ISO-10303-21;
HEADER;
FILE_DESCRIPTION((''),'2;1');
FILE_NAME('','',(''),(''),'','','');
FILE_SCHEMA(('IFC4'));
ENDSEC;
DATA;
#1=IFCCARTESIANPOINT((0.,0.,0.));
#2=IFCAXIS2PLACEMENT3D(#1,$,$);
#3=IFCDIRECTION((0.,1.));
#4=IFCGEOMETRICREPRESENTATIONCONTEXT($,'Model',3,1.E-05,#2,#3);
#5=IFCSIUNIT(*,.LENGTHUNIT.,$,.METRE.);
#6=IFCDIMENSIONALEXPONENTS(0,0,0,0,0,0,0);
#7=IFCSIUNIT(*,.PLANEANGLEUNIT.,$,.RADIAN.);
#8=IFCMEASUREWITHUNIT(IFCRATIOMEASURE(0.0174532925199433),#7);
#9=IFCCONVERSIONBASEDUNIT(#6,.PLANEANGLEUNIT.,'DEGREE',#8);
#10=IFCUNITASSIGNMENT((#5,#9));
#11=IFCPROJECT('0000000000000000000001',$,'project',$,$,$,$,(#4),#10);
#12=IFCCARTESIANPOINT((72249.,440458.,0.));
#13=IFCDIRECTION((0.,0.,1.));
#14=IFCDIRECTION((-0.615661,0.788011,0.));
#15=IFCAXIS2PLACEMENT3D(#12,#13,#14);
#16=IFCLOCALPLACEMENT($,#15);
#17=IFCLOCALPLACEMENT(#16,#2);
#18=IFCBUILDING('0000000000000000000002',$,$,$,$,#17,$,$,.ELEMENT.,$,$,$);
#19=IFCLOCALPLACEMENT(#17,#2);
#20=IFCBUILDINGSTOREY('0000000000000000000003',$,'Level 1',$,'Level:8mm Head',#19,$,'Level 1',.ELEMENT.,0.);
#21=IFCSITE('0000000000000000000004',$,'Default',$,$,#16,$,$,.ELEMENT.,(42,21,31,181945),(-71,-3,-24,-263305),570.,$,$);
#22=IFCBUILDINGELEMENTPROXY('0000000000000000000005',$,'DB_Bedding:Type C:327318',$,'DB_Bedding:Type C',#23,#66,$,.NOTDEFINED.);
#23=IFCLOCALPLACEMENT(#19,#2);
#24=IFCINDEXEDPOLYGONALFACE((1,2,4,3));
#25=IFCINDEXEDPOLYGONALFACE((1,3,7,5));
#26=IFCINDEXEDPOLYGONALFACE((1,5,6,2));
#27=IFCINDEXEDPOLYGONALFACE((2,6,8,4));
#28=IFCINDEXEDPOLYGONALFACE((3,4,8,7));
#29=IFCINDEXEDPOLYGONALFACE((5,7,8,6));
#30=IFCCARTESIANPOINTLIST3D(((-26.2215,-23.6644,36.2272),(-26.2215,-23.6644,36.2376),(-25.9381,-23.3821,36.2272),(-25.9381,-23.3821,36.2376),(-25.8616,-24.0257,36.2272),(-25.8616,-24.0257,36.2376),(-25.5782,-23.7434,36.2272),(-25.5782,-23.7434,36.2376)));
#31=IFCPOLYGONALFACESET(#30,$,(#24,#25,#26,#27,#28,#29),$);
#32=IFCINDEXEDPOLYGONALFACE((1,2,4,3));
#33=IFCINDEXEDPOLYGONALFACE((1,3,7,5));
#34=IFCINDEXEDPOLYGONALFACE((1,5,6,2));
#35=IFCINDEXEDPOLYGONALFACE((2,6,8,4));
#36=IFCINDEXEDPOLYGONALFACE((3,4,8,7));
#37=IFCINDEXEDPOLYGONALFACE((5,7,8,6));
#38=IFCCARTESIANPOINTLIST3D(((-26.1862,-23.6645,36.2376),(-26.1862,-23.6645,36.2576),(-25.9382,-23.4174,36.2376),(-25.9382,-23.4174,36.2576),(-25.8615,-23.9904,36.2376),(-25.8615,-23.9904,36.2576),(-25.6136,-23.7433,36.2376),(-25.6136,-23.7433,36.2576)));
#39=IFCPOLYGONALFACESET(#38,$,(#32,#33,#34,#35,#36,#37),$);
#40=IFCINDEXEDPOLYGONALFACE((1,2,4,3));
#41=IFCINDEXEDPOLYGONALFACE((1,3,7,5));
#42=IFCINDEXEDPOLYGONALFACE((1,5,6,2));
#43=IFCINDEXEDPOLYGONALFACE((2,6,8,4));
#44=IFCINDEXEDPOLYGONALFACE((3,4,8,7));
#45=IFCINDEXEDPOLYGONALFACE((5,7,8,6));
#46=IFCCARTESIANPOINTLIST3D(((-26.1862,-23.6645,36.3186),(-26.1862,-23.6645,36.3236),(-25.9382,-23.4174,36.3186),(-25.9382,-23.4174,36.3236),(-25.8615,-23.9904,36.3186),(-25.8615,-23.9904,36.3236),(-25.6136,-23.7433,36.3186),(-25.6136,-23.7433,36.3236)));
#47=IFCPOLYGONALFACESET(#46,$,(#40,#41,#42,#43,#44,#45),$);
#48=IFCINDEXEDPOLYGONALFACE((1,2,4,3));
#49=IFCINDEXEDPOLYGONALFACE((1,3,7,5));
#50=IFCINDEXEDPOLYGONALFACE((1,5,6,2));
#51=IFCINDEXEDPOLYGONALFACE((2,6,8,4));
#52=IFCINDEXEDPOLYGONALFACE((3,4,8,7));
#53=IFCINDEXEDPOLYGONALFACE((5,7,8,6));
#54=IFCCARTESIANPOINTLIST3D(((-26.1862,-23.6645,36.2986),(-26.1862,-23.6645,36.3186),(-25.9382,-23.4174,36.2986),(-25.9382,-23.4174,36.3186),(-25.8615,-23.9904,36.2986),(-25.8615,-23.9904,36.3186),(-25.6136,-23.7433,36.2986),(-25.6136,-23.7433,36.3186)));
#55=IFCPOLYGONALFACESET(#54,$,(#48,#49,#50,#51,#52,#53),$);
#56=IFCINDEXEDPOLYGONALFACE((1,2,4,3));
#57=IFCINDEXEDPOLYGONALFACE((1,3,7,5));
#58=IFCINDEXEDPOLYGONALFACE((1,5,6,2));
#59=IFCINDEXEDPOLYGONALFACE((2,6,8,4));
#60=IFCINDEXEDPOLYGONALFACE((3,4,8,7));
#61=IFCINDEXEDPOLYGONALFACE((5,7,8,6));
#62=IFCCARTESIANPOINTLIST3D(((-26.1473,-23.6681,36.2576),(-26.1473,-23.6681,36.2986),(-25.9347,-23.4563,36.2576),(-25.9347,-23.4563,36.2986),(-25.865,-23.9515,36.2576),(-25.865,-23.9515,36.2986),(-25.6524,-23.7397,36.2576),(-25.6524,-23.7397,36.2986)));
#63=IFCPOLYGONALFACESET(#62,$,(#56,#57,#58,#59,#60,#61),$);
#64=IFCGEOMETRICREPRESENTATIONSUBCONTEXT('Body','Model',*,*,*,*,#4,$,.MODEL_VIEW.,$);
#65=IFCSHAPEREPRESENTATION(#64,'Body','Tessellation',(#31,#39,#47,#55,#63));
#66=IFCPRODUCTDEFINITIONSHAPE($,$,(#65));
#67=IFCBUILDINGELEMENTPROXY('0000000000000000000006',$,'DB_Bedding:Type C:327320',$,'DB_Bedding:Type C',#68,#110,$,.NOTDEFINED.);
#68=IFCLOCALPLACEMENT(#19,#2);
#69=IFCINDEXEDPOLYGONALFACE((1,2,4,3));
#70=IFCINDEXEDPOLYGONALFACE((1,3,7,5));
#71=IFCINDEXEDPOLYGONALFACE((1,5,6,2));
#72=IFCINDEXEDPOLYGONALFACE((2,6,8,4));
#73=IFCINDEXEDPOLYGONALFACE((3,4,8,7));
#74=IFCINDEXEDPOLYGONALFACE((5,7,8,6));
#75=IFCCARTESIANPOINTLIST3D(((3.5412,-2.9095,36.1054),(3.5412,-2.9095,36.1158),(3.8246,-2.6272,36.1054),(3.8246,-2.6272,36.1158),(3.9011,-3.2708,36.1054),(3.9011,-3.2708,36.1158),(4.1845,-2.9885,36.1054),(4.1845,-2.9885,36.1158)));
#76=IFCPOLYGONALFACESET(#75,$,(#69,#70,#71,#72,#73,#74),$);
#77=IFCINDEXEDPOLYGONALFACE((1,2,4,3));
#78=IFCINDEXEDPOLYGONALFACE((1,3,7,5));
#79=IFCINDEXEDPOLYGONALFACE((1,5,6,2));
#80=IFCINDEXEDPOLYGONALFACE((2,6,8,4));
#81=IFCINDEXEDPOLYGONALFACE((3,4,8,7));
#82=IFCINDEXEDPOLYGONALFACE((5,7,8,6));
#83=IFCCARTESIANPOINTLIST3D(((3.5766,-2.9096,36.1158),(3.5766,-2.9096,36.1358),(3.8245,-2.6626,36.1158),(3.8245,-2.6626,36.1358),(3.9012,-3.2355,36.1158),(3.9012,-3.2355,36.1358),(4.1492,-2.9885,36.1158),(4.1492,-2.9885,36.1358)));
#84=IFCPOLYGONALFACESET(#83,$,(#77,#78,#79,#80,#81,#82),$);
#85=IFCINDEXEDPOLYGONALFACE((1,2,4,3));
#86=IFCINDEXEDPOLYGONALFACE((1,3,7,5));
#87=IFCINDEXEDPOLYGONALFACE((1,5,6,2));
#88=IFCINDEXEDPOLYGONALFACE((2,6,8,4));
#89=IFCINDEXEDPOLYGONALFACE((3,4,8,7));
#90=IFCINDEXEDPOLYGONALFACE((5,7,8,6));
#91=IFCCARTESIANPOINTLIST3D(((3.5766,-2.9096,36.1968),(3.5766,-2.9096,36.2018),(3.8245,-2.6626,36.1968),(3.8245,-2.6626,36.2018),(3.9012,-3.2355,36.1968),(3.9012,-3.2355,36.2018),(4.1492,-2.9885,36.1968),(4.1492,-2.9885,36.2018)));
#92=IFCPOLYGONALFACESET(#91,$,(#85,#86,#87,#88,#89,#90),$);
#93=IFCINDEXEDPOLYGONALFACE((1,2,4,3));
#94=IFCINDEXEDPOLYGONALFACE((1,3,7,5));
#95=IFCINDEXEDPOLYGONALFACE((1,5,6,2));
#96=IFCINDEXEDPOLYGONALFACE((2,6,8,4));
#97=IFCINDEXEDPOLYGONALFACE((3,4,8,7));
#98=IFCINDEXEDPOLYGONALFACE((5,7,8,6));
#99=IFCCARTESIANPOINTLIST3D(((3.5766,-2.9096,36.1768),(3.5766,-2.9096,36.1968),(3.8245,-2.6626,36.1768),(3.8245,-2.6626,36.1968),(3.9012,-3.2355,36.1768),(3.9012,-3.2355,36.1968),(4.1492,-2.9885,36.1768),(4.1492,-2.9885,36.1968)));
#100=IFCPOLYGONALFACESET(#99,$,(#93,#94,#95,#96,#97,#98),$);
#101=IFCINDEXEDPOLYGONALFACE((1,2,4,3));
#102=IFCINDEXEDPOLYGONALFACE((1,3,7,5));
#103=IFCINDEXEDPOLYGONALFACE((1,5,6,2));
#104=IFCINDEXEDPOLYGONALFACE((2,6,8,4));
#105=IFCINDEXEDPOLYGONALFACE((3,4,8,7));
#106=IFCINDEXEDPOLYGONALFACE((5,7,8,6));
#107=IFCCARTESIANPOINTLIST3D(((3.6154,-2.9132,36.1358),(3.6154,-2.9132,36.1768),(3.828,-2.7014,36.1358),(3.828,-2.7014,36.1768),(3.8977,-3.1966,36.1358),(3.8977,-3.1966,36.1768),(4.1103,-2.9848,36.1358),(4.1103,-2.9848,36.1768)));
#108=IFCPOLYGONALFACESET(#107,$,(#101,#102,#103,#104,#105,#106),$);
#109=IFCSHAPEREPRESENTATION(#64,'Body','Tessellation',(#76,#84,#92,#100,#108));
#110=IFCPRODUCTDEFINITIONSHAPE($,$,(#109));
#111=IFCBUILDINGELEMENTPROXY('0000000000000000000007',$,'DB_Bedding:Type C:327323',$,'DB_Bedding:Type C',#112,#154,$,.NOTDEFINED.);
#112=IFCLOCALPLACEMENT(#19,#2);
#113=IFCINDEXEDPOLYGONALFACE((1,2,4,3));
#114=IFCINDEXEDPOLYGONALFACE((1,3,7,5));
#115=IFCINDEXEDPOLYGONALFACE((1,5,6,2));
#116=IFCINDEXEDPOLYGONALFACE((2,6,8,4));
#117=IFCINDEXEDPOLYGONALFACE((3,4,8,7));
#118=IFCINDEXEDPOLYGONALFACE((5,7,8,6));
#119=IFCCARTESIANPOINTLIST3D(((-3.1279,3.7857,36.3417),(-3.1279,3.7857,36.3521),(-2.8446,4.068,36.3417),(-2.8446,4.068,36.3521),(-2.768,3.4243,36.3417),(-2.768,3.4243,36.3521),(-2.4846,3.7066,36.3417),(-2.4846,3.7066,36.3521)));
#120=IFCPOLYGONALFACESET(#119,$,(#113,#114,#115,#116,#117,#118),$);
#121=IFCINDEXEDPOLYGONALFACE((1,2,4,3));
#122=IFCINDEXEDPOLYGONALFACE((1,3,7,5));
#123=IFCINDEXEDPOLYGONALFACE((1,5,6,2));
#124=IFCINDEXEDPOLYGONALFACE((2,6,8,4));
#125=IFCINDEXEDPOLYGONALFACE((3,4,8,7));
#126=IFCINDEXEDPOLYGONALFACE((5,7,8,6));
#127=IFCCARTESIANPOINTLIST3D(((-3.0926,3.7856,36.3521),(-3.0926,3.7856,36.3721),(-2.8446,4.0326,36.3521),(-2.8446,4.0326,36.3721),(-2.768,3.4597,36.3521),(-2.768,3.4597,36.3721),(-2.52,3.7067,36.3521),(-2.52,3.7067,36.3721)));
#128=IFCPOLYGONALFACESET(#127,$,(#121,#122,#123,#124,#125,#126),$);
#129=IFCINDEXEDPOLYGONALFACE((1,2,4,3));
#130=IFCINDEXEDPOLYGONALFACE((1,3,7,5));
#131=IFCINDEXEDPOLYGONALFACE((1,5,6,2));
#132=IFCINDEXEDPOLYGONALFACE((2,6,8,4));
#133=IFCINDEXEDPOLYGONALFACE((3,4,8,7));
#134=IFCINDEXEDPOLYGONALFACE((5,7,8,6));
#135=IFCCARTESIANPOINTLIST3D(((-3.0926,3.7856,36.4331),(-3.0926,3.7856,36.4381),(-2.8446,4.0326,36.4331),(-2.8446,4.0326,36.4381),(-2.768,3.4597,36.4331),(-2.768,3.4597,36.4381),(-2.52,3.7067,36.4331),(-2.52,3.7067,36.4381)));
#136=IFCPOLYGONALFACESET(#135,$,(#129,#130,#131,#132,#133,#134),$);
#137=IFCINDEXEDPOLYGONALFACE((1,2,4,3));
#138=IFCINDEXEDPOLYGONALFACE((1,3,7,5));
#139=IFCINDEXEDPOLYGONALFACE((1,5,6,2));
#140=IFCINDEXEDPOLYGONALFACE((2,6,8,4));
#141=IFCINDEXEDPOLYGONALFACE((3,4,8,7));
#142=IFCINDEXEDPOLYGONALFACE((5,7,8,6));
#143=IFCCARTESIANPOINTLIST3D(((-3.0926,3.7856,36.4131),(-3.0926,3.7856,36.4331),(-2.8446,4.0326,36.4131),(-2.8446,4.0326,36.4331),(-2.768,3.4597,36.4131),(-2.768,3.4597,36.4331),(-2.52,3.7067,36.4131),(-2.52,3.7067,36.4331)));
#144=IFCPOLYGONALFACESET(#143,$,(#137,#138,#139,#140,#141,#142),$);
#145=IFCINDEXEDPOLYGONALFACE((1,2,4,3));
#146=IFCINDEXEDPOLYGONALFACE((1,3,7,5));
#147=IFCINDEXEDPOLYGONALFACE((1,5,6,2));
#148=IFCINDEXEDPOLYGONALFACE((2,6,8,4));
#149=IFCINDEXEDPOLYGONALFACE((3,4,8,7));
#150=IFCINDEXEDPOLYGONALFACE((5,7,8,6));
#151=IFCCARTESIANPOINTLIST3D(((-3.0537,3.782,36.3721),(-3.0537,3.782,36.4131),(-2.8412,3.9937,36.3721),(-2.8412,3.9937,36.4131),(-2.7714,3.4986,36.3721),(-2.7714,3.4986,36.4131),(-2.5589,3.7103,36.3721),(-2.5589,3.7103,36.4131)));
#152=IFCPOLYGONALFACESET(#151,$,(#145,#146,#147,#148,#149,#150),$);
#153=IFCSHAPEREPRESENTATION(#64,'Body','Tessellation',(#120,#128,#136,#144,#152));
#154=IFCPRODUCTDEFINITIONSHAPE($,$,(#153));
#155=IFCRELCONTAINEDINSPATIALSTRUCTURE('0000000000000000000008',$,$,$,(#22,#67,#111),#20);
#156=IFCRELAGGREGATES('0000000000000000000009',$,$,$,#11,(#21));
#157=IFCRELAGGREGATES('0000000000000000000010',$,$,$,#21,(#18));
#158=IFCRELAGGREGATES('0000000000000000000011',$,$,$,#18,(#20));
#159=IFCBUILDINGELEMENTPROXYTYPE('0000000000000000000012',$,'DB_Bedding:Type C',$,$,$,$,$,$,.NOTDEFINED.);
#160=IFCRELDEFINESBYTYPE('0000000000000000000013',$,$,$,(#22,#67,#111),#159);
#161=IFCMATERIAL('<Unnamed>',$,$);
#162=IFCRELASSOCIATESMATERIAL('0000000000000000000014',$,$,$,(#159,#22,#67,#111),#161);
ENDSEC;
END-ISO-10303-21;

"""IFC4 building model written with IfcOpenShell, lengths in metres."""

from ifc_helpers import new_model, entity, si_unit, converted_unit, direction, frame, origin, origin_2d_with_axis, place, context, subcontext, project, spatial, rectangle, extrude, source, transform, mapped, material, type_object, type_shapes, element, save


model = new_model("IFC4")

# Units and contexts
model_context = context("Model", 3, precision=1e-05, world=origin(), true_north=direction((0.0, 1.0)))
body_context = subcontext(model_context, "Body", "Model", "MODEL_VIEW")
ifc_project = project(units=[si_unit("LENGTHUNIT", "METRE"), converted_unit("PLANEANGLEUNIT", "DEGREE", entity("IfcRatioMeasure", 0.0174532925199433), si_unit("PLANEANGLEUNIT", "RADIAN"), dimensions=[0, 0, 0, 0, 0, 0, 0])], contexts=[model_context])

# Site, building, storey
site_placement = place(None, frame((72249.0, 440458.0, 0.0), z_axis=(0.0, 0.0, 1.0), x_axis=(-0.615661, 0.788011, 0.0)))
site = spatial("IfcSite", under=ifc_project, at=site_placement, Name="Default", CompositionType="ELEMENT", RefLatitude=(42, 21, 31, 181945), RefLongitude=(-71, -3, -24, -263305), RefElevation=570.0)
building_placement = place(site_placement, origin())
building = spatial("IfcBuilding", under=site, at=building_placement, CompositionType="ELEMENT")
storey_placement = place(building_placement, origin())
storey = spatial("IfcBuildingStorey", under=building, at=storey_placement, Name="Level 1", ObjectType="Level:8mm Head", LongName="Level 1", CompositionType="ELEMENT", Elevation=0.0)

# Building element proxies
ifc_material = material(Name="<Unnamed>")
building_element_proxy_type_1 = type_object("IfcBuildingElementProxyType", Name="DB_Bedding:Type C", PredefinedType="NOTDEFINED", material=ifc_material)
shared_shape_1 = source(origin(), body_context, "Body", "SweptSolid", [
    extrude(rectangle(XDim=0.4, YDim=0.51, at=origin_2d_with_axis()), frame((0.0, 0.0, -0.0965), z_axis=(0.0, 0.0, 1.0), x_axis=(0.0, 1.0, 0.0)), (0.0, 0.0, 1.0), 0.0105),
    extrude(rectangle(XDim=0.35, YDim=0.46, at=origin_2d_with_axis()), frame((0.0, 0.0, -0.086), z_axis=(0.0, 0.0, 1.0), x_axis=(0.0, 1.0, 0.0)), (0.0, 0.0, 1.0), 0.02),
    extrude(rectangle(XDim=0.35, YDim=0.46, at=origin_2d_with_axis()), frame((0.0, 0.0, -0.005), z_axis=(0.0, 0.0, 1.0), x_axis=(0.0, 1.0, 0.0)), (0.0, 0.0, 1.0), 0.005),
    extrude(rectangle(XDim=0.35, YDim=0.46, at=origin_2d_with_axis()), frame((0.0, 0.0, -0.025), z_axis=(0.0, 0.0, 1.0), x_axis=(0.0, 1.0, 0.0)), (0.0, 0.0, 1.0), 0.02),
    extrude(rectangle(XDim=0.3, YDim=0.4, at=origin_2d_with_axis()), frame((0.0, 0.0, -0.066), z_axis=(0.0, 0.0, 1.0), x_axis=(0.0, 1.0, 0.0)), (0.0, 0.0, 1.0), 0.041),
])
type_shapes(building_element_proxy_type_1, [shared_shape_1])
for number, where, z_axis, x_axis, name in (
    (1, (-25.8999, -23.7039, 36.3236), (0.0, 0.0, 1.0), (0.70573, -0.708481, 0.0), "DB_Bedding:Type C:327318"),
    (2, (3.8629, -2.949, 36.2018), (0.0, 0.0, 1.0), (0.70573, -0.708481, 0.0), "DB_Bedding:Type C:327320"),
    (3, (-2.8063, 3.7461, 36.4381), (0.0, 0.0, 1.0), (0.70573, -0.708481, 0.0), "DB_Bedding:Type C:327323"),
):
    element("IfcBuildingElementProxy", number, at=place(storey_placement, frame(where, z_axis=z_axis, x_axis=x_axis)), inside=storey, type_object=building_element_proxy_type_1, material=ifc_material, Name=name, ObjectType="DB_Bedding:Type C", PredefinedType="NOTDEFINED", context=body_context, shape_type="MappedRepresentation", body=[
        mapped(shared_shape_1, transform((0.0, 0.0, 0.0), scale=1.0)),
    ])

save(model, "model.ifc")
